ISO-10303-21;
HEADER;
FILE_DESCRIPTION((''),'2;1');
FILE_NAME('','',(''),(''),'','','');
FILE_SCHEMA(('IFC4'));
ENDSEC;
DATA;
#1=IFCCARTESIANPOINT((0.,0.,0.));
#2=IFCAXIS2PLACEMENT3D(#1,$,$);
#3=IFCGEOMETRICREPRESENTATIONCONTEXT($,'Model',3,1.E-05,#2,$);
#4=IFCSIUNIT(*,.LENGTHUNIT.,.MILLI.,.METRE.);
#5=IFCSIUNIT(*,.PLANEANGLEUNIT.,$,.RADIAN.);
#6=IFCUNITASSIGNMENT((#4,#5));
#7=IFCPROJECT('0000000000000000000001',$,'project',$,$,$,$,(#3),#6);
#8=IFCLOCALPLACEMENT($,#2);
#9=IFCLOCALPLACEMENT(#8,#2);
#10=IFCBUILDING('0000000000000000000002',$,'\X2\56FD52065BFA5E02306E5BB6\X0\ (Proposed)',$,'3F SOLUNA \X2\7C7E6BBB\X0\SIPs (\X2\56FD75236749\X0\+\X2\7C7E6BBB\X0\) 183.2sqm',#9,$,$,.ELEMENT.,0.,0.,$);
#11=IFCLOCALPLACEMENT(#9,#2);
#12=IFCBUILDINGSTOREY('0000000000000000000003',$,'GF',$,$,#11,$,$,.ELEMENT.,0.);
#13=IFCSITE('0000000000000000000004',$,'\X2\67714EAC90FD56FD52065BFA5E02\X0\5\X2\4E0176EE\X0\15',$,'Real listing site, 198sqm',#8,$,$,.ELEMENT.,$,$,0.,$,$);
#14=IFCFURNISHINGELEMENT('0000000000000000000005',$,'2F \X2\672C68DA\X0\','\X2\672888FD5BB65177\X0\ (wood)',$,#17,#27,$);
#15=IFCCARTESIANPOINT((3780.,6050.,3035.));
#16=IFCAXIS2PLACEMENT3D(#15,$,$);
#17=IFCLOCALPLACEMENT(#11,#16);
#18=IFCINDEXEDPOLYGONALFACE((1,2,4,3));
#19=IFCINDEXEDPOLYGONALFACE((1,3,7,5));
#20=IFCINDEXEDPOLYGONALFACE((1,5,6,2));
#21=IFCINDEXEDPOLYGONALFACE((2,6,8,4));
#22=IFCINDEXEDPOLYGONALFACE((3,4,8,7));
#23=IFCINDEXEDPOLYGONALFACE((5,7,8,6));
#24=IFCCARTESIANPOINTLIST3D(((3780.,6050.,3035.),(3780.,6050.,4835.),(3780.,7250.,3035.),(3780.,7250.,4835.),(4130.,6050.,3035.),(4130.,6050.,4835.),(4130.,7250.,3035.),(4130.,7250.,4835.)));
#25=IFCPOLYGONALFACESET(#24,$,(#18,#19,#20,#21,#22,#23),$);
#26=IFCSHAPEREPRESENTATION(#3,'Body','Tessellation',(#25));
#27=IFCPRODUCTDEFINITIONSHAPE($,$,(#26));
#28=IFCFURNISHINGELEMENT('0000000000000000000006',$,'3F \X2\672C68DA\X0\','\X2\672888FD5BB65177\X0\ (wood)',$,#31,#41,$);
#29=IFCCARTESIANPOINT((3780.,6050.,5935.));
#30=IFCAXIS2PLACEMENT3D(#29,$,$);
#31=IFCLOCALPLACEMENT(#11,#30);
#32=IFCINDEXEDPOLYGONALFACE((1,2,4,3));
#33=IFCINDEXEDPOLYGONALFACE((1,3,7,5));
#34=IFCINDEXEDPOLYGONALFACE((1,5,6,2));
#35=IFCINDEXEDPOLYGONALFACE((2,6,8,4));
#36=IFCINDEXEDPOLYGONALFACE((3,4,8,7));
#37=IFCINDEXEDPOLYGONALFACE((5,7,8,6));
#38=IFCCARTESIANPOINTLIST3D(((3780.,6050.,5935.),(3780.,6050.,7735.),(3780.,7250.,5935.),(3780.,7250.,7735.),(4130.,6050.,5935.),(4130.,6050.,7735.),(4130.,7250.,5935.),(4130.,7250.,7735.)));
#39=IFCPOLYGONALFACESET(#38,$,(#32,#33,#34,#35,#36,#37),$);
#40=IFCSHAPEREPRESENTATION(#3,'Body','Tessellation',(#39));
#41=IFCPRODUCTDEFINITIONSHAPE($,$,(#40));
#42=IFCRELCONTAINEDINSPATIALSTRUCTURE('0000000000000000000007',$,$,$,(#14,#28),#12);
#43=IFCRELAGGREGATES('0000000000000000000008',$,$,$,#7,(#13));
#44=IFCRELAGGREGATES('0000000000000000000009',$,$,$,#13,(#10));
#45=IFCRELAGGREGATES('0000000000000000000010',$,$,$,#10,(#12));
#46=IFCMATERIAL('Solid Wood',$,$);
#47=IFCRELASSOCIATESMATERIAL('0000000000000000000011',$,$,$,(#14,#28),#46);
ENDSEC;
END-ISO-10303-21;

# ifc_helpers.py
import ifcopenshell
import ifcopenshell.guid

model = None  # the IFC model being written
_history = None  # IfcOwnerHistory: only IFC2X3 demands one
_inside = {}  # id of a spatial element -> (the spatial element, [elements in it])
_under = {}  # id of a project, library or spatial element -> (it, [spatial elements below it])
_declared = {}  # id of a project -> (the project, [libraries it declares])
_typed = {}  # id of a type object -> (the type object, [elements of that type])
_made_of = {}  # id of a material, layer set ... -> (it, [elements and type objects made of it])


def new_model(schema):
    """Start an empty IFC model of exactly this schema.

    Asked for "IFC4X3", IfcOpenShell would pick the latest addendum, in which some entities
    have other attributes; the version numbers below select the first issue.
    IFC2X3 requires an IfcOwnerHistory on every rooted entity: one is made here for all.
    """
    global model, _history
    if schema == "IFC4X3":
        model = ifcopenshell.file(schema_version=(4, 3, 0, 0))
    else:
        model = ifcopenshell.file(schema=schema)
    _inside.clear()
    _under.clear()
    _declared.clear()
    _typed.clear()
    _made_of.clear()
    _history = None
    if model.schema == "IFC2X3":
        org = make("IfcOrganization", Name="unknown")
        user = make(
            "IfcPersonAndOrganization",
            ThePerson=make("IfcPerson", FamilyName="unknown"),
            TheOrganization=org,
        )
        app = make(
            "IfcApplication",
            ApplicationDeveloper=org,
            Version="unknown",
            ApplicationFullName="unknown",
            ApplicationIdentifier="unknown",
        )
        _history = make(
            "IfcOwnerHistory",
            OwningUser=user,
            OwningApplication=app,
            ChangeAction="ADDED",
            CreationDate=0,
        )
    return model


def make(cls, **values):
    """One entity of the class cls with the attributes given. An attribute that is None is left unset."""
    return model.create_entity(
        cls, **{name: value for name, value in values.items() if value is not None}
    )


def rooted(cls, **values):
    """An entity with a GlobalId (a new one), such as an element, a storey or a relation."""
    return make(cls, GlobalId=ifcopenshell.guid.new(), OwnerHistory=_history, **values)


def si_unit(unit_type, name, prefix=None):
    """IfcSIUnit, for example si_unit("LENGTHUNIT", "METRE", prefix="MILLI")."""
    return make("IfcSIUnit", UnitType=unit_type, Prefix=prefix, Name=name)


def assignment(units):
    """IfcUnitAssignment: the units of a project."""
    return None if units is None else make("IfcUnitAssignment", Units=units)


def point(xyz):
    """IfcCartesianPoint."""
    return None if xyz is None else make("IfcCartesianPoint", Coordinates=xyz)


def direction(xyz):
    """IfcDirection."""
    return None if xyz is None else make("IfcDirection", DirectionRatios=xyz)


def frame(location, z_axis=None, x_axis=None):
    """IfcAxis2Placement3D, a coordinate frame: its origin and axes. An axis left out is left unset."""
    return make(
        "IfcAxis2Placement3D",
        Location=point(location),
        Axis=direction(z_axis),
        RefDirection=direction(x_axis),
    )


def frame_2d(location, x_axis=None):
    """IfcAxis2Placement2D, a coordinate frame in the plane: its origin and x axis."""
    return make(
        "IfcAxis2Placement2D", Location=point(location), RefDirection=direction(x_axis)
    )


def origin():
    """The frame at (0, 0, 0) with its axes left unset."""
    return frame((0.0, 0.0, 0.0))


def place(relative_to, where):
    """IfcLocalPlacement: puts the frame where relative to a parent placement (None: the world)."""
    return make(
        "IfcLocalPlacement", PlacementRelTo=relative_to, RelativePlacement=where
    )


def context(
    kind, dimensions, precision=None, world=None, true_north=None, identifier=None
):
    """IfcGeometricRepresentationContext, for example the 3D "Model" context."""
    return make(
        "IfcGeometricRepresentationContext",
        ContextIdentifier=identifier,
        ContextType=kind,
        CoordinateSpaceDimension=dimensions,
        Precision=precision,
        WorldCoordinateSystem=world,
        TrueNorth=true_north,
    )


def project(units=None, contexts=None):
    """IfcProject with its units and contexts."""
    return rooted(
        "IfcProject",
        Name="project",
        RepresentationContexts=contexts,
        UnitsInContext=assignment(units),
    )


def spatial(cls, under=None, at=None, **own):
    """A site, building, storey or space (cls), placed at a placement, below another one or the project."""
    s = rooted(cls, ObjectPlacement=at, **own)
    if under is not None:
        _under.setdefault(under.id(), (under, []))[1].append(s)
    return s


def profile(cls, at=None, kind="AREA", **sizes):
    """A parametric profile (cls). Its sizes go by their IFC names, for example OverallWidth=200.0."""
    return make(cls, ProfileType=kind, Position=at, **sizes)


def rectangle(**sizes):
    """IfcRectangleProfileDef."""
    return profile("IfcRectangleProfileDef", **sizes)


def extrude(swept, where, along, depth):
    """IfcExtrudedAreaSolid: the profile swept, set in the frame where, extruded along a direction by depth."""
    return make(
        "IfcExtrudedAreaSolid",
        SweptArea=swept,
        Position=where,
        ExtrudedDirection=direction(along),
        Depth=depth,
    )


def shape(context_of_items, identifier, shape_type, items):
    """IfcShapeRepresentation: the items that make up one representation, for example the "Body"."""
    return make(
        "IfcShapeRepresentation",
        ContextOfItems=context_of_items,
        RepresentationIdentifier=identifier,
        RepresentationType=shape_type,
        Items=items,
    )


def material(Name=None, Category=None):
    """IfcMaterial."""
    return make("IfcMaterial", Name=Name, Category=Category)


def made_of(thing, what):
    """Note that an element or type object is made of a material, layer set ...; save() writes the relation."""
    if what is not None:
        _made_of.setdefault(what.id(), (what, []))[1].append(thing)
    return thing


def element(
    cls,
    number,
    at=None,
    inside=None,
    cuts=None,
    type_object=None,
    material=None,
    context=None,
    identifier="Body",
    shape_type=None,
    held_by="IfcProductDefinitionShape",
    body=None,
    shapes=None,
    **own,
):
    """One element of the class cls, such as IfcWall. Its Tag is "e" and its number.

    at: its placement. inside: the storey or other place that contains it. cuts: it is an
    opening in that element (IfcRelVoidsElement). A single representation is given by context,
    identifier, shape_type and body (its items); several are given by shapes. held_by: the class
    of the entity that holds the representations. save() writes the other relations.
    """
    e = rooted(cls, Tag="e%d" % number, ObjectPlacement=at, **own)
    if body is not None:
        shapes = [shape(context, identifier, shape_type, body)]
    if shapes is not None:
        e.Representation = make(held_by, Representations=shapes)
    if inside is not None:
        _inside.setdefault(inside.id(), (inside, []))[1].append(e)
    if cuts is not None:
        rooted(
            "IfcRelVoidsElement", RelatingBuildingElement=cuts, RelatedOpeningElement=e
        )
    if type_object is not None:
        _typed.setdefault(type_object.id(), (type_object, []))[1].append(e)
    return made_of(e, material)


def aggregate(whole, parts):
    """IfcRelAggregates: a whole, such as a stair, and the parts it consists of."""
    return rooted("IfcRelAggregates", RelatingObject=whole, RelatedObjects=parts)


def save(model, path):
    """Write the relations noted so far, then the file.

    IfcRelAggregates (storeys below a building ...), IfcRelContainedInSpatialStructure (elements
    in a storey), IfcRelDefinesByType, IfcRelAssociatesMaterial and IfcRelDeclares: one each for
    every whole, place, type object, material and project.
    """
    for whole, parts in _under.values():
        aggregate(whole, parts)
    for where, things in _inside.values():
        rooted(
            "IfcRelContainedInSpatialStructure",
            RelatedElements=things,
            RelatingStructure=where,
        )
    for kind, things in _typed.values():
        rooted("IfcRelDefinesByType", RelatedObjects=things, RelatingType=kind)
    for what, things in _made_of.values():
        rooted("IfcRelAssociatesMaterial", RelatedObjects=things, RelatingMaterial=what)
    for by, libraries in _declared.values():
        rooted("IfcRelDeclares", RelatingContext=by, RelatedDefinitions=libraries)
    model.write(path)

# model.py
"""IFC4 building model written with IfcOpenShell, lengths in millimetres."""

from ifc_helpers import new_model, si_unit, frame, frame_2d, origin, place, context, project, spatial, rectangle, extrude, material, element, save


model = new_model("IFC4")

# Units and contexts
model_context = context("Model", 3, precision=1e-05, world=origin())
ifc_project = project(units=[si_unit("LENGTHUNIT", "METRE", prefix="MILLI"), si_unit("PLANEANGLEUNIT", "RADIAN")], contexts=[model_context])

# Site, building, storey
site_placement = place(None, origin())
site = spatial("IfcSite", under=ifc_project, at=site_placement, Name="東京都国分寺市5丁目15", ObjectType="Real listing site, 198sqm", CompositionType="ELEMENT", RefElevation=0.0)
building_placement = place(site_placement, origin())
building = spatial("IfcBuilding", under=site, at=building_placement, Name="国分寺市の家 (Proposed)", ObjectType="3F SOLUNA 籾殻SIPs (国産杉+籾殻) 183.2sqm", CompositionType="ELEMENT", ElevationOfRefHeight=0.0, ElevationOfTerrain=0.0)
storey_placement = place(building_placement, origin())
storey = spatial("IfcBuildingStorey", under=building, at=storey_placement, Name="GF", CompositionType="ELEMENT", Elevation=0.0)

# Shared definitions
ifc_material_1 = material(Name="Solid Wood")

# Furnishing elements
furnishing_1_placement = place(storey_placement, frame((3780.0, 6050.0, 3035.0)))
element("IfcFurnishingElement", 1, at=furnishing_1_placement, inside=storey, material=ifc_material_1, Name="2F 本棚", Description="木製家具 (wood)", context=model_context, shape_type="SweptSolid", body=[
    extrude(rectangle(XDim=350.0, YDim=1200.0, at=frame_2d((175.0, 600.0))), frame((3780.0, 6050.0, 3035.0)), (0.0, 0.0, 1.0), 1800.0),
])
furnishing_2_placement = place(storey_placement, frame((3780.0, 6050.0, 5935.0)))
element("IfcFurnishingElement", 2, at=furnishing_2_placement, inside=storey, material=ifc_material_1, Name="3F 本棚", Description="木製家具 (wood)", context=model_context, shape_type="SweptSolid", body=[
    extrude(rectangle(XDim=350.0, YDim=1200.0, at=frame_2d((175.0, 600.0))), frame((3780.0, 6050.0, 5935.0)), (0.0, 0.0, 1.0), 1800.0),
])

save(model, "model.ifc")
